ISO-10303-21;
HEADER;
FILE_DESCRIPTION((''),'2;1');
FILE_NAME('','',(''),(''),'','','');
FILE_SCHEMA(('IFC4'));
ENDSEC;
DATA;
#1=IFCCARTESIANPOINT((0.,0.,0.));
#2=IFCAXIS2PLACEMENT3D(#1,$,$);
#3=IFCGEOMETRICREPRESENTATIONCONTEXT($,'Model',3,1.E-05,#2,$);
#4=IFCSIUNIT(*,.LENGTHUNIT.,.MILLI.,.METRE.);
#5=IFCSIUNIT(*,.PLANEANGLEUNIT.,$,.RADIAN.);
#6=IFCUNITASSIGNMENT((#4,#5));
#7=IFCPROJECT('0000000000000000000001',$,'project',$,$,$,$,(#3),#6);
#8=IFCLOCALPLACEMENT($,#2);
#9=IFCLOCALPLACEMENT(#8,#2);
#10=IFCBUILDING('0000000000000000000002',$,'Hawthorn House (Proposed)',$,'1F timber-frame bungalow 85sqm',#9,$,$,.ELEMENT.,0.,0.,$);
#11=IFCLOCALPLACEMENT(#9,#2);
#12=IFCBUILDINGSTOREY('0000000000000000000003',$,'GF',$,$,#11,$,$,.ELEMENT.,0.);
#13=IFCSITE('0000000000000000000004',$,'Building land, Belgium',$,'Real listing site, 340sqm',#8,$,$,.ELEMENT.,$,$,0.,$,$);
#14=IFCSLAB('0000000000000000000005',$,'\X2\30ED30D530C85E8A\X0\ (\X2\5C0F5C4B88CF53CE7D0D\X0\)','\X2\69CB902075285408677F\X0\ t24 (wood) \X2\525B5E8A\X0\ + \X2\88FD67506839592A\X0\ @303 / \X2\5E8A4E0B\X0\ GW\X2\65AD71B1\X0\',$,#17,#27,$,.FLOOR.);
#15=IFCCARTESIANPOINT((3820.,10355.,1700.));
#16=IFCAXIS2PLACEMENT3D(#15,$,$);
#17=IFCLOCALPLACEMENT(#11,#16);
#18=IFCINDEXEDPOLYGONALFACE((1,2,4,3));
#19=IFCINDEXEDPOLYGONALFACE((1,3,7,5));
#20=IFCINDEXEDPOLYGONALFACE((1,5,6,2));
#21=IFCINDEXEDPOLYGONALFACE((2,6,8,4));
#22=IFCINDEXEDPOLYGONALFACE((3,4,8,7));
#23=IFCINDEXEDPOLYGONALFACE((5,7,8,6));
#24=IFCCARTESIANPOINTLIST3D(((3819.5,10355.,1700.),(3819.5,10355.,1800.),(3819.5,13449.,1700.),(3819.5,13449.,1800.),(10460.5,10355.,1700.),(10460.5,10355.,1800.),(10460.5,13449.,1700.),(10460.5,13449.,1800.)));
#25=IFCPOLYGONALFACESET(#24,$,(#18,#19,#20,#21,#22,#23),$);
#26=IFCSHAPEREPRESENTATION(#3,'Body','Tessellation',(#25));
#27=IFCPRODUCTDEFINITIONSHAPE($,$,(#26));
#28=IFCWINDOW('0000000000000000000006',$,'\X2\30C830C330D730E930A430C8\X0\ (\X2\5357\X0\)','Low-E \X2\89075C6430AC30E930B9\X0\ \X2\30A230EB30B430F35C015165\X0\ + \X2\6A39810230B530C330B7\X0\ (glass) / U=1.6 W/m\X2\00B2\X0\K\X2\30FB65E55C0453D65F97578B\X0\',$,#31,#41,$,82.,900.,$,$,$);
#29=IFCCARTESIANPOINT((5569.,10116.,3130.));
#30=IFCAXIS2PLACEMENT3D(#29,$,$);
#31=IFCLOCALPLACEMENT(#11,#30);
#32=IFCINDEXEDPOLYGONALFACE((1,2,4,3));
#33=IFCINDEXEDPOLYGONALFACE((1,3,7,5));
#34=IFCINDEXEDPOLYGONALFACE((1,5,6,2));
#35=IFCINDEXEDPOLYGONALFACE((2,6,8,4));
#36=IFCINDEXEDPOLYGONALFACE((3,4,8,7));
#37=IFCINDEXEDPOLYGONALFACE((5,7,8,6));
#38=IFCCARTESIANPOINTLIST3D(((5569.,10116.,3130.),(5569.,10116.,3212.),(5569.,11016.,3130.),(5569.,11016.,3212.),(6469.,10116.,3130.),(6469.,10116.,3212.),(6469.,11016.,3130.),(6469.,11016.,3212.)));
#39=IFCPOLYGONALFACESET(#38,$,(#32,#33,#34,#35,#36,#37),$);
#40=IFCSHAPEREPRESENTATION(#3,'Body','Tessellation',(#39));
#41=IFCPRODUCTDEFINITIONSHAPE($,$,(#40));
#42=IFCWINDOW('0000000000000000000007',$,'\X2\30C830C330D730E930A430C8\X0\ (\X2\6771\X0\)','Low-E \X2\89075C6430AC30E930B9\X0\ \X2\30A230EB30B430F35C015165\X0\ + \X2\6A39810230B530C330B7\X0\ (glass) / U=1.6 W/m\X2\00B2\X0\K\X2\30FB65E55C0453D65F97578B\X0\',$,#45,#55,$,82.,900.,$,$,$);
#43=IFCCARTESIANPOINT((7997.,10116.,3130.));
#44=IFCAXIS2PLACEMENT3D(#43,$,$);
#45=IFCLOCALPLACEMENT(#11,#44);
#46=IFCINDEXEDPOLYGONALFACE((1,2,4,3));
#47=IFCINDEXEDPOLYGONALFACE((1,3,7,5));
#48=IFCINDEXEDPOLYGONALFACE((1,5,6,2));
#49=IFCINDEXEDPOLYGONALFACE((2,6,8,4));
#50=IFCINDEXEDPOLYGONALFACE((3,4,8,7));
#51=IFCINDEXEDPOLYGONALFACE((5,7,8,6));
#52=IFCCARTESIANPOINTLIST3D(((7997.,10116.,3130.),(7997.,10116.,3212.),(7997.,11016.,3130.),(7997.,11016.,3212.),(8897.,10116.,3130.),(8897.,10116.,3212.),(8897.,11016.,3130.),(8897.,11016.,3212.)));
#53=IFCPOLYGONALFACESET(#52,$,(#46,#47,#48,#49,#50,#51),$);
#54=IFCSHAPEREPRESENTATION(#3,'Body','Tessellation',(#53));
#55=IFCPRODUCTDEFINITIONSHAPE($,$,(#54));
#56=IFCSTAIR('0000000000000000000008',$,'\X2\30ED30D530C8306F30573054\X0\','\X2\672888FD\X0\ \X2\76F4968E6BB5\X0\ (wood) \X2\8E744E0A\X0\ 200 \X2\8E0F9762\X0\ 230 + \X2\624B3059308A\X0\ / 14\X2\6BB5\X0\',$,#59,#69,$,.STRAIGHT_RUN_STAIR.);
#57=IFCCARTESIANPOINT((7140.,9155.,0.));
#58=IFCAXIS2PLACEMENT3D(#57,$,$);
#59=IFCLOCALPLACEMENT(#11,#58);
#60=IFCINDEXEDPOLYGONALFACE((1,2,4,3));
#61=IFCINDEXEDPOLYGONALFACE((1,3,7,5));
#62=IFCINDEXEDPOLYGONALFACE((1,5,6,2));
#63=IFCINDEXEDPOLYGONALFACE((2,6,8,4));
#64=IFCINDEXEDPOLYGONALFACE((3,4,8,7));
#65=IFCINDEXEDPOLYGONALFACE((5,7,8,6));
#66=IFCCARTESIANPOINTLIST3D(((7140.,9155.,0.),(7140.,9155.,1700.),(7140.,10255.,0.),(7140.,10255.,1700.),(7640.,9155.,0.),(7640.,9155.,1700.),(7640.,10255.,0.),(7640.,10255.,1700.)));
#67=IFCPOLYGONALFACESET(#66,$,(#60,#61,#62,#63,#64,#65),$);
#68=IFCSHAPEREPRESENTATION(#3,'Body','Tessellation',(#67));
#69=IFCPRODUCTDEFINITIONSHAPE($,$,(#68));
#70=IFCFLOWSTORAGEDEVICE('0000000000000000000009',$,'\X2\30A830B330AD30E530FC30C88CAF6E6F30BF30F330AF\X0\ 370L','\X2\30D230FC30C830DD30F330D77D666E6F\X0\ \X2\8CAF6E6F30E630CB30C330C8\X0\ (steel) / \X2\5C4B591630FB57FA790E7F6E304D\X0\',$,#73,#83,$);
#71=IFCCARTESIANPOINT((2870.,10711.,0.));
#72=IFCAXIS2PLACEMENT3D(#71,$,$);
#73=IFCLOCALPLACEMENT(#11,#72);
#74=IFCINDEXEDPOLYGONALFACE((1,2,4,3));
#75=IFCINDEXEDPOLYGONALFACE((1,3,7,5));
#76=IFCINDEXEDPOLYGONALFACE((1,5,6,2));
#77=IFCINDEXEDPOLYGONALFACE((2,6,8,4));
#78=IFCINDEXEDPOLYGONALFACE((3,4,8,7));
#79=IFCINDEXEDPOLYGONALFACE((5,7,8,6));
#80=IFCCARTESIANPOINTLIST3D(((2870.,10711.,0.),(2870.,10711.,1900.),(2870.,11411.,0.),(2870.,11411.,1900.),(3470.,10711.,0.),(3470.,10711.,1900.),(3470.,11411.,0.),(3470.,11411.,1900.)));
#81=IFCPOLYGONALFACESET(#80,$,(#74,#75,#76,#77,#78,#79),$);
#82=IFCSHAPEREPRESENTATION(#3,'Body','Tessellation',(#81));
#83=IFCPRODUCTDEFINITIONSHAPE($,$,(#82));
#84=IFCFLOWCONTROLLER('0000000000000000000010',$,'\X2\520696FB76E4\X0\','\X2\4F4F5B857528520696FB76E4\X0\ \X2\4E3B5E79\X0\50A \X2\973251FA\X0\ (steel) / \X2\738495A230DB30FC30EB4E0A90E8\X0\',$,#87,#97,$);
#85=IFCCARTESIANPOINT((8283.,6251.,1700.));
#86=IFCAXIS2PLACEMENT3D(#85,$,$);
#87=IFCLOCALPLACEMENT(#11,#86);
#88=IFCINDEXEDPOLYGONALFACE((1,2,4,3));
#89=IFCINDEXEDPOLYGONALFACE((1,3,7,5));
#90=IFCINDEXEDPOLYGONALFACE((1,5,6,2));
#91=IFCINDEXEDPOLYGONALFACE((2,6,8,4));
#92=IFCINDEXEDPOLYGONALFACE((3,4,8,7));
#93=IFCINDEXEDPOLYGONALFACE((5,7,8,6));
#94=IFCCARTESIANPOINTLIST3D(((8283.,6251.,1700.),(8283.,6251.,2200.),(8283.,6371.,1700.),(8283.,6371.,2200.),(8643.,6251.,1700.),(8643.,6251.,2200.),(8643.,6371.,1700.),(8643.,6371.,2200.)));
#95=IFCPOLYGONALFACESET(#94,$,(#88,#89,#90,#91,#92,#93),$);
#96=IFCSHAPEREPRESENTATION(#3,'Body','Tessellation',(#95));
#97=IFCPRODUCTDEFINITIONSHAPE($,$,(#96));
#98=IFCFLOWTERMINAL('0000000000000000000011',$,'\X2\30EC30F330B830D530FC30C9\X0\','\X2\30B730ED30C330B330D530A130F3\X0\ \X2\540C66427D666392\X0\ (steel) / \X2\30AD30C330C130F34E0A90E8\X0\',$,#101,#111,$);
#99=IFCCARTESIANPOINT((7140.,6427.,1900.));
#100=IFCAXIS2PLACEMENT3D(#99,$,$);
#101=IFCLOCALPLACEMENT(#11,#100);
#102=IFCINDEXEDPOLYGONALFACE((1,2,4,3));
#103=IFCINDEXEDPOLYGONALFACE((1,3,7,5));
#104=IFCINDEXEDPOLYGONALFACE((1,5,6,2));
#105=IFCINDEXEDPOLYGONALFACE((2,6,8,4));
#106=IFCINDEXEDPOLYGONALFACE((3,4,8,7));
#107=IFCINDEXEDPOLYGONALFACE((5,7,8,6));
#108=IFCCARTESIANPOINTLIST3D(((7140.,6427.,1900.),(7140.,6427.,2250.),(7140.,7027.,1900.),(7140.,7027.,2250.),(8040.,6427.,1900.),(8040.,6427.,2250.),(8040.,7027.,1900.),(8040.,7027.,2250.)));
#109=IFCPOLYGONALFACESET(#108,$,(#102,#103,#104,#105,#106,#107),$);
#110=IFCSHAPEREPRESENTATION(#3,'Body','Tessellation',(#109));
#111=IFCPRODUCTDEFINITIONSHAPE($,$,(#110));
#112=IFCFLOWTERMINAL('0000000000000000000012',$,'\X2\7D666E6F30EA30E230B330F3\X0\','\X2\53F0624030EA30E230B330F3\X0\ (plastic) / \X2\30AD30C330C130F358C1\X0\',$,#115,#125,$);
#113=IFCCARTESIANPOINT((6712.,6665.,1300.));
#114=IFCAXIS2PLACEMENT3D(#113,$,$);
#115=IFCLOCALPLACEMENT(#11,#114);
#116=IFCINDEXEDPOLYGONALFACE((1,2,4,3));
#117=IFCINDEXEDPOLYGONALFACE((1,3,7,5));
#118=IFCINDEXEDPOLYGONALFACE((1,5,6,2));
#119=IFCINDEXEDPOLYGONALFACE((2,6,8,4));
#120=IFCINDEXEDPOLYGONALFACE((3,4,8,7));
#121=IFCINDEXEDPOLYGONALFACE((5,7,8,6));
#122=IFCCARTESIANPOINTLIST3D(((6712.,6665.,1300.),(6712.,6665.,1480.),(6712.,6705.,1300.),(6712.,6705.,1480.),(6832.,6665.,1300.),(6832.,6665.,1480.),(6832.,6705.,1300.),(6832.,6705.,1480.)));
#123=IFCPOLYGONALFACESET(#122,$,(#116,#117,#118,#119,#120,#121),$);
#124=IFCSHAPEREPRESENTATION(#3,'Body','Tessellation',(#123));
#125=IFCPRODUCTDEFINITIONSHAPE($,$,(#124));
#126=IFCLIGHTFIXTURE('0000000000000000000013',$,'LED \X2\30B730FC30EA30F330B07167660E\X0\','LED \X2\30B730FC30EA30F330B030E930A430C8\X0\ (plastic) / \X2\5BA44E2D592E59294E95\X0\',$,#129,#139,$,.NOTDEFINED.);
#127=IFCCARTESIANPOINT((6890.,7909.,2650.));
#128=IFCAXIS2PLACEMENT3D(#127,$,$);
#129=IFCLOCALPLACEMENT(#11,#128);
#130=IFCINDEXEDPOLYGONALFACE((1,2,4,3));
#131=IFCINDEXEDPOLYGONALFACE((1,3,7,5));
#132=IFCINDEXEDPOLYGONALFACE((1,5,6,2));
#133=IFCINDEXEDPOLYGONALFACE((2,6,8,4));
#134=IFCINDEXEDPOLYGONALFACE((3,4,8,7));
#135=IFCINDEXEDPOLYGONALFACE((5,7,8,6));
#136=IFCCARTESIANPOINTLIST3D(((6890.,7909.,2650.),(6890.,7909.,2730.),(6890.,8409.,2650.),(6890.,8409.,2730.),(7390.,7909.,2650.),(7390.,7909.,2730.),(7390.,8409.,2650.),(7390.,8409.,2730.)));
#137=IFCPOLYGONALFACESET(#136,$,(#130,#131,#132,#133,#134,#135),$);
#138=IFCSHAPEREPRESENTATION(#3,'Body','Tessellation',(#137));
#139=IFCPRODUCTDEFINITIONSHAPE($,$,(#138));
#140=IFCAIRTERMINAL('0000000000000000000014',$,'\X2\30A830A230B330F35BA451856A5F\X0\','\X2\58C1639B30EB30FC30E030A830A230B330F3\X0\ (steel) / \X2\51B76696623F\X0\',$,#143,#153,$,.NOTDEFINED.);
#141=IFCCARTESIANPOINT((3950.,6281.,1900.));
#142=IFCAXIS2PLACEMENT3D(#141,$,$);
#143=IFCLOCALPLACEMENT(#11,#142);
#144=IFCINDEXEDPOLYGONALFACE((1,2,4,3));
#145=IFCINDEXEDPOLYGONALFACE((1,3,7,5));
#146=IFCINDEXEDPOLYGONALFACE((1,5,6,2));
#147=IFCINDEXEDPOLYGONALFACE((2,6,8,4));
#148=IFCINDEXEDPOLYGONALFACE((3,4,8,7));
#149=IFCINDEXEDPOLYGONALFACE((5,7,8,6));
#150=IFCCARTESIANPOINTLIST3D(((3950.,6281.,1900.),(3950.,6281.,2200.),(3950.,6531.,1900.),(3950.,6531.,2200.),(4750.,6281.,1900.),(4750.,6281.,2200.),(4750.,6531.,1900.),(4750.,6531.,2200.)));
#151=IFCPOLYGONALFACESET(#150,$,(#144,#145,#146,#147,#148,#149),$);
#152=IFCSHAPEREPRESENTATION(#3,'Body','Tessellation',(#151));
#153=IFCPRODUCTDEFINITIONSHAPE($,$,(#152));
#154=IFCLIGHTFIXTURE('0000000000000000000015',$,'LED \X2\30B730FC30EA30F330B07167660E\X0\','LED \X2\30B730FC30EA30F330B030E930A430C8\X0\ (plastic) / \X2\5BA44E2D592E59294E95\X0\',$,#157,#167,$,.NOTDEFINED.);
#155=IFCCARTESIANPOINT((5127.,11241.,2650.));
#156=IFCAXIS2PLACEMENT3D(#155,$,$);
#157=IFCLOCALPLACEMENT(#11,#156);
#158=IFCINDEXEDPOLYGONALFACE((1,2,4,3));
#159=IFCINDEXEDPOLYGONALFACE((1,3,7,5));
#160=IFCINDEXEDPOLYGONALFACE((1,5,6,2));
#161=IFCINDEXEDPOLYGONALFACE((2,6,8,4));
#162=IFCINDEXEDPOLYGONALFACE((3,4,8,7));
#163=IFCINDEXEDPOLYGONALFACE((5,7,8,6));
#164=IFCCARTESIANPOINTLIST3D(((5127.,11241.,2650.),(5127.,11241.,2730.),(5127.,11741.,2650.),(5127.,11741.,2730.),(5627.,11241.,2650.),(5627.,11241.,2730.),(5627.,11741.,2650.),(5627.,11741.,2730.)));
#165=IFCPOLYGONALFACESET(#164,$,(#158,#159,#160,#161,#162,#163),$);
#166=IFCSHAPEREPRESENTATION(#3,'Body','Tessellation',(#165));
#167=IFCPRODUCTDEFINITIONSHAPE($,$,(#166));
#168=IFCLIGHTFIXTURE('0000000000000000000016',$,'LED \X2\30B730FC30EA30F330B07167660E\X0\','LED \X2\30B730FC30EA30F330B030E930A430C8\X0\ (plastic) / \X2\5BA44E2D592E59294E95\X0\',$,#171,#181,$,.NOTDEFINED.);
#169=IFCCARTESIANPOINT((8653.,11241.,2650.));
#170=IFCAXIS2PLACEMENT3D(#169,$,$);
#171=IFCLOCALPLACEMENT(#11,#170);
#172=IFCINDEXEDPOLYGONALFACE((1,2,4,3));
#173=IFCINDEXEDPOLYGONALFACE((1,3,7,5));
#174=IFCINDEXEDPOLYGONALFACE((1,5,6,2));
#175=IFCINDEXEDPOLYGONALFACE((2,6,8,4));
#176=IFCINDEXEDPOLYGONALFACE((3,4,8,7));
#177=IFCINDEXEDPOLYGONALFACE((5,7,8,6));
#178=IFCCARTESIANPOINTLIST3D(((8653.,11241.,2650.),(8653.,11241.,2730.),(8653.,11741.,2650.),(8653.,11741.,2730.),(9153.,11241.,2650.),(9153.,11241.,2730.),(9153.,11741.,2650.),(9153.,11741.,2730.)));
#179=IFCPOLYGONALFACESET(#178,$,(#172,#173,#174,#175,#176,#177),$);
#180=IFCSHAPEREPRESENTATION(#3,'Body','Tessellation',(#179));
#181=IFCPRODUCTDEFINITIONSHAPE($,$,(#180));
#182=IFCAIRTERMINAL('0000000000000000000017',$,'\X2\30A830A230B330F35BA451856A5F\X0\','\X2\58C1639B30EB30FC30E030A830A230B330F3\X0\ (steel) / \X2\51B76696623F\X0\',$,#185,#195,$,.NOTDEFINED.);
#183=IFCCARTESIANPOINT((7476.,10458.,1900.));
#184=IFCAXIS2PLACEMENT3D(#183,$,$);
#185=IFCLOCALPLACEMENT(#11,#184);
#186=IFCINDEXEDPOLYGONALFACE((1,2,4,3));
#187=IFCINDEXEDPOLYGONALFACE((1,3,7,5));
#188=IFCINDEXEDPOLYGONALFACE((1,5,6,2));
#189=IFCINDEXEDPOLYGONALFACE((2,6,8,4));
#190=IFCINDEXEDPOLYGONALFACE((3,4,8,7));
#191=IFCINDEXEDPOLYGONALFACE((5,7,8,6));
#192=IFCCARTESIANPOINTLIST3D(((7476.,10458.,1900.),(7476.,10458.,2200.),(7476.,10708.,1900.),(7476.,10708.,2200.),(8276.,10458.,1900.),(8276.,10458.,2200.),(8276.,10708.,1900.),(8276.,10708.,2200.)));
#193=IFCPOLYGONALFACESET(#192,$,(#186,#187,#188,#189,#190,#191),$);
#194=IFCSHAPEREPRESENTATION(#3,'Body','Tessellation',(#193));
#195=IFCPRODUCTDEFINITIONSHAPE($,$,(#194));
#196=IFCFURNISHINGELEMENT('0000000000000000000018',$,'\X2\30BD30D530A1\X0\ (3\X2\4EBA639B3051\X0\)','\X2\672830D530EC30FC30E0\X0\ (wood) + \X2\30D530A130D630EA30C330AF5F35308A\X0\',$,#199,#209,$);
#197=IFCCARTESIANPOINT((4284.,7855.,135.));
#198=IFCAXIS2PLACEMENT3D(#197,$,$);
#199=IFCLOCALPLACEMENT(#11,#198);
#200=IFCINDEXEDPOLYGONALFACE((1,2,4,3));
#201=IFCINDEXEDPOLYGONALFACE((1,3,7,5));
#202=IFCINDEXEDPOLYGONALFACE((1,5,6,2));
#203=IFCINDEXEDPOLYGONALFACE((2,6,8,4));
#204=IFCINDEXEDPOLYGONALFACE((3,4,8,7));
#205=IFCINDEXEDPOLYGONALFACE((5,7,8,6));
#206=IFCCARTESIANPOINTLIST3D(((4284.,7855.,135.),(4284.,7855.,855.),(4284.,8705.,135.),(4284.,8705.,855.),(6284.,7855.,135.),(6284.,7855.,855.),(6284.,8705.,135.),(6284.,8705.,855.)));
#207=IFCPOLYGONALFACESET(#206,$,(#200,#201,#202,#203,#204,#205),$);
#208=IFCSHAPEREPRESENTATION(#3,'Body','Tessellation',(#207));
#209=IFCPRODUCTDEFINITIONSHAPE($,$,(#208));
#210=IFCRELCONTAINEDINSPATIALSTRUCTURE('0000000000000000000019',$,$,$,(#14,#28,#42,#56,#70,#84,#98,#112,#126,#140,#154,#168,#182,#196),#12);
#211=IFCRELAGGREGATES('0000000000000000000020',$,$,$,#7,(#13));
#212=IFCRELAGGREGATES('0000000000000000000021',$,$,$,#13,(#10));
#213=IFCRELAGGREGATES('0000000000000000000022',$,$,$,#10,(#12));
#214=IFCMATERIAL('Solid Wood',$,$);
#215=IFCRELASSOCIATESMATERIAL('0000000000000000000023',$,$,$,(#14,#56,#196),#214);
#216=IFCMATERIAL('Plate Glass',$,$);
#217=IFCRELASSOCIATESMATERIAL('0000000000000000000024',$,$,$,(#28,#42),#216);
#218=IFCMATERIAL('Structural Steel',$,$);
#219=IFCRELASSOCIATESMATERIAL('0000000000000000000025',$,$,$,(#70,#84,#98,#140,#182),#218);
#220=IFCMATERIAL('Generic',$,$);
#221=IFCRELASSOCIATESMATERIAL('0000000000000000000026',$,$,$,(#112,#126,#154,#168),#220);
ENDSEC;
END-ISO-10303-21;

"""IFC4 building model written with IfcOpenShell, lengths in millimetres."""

from ifc_helpers import new_model, si_unit, frame, frame_2d, origin, place, context, project, spatial, rectangle, extrude, material, element, save


model = new_model("IFC4")

# Units and contexts
model_context = context("Model", 3, precision=1e-05, world=origin())
ifc_project = project(units=[si_unit("LENGTHUNIT", "METRE", prefix="MILLI"), si_unit("PLANEANGLEUNIT", "RADIAN")], contexts=[model_context])

# Site, building, storey
site_placement = place(None, origin())
site = spatial("IfcSite", under=ifc_project, at=site_placement, Name="Building land, Belgium", ObjectType="Real listing site, 340sqm", CompositionType="ELEMENT", RefElevation=0.0)
building_placement = place(site_placement, origin())
building = spatial("IfcBuilding", under=site, at=building_placement, Name="Hawthorn House (Proposed)", ObjectType="1F timber-frame bungalow 85sqm", CompositionType="ELEMENT", ElevationOfRefHeight=0.0, ElevationOfTerrain=0.0)
storey_placement = place(building_placement, origin())
storey = spatial("IfcBuildingStorey", under=building, at=storey_placement, Name="GF", CompositionType="ELEMENT", Elevation=0.0)

# Shared definitions
ifc_material_1 = material(Name="Solid Wood")

# Slab
slab_placement = place(storey_placement, frame((3820.0, 10355.0, 1700.0)))
element("IfcSlab", 1, at=slab_placement, inside=storey, material=ifc_material_1, Name="ロフト床 (小屋裏収納)", Description="構造用合板 t24 (wood) 剛床 + 製材根太 @303 / 床下 GW断熱", PredefinedType="FLOOR", context=model_context, shape_type="SweptSolid", body=[
    extrude(rectangle(XDim=6641.0, YDim=3094.0, at=frame_2d((3320.0, 1547.0))), frame((3820.0, 10355.0, 1700.0)), (0.0, 0.0, 1.0), 100.0),
])

# Windows
ifc_material_2 = material(Name="Plate Glass")
window_1_placement = place(storey_placement, frame((5569.0, 10116.0, 3130.0)))
element("IfcWindow", 2, at=window_1_placement, inside=storey, material=ifc_material_2, Name="トップライト (南)", Description="Low-E 複層ガラス アルゴン封入 + 樹脂サッシ (glass) / U=1.6 W/m²K・日射取得型", OverallHeight=82.0, OverallWidth=900.0, context=model_context, shape_type="SweptSolid", body=[
    extrude(rectangle(XDim=900.0, YDim=900.0, at=frame_2d((450.0, 450.0))), frame((5569.0, 10116.0, 3130.0)), (0.0, 0.0, 1.0), 82.0),
])
window_2_placement = place(storey_placement, frame((7997.0, 10116.0, 3130.0)))
element("IfcWindow", 3, at=window_2_placement, inside=storey, material=ifc_material_2, Name="トップライト (東)", Description="Low-E 複層ガラス アルゴン封入 + 樹脂サッシ (glass) / U=1.6 W/m²K・日射取得型", OverallHeight=82.0, OverallWidth=900.0, context=model_context, shape_type="SweptSolid", body=[
    extrude(rectangle(XDim=900.0, YDim=900.0, at=frame_2d((450.0, 450.0))), frame((7997.0, 10116.0, 3130.0)), (0.0, 0.0, 1.0), 82.0),
])

# Stair
stair_placement = place(storey_placement, frame((7140.0, 9155.0, 0.0)))
element("IfcStair", 4, at=stair_placement, inside=storey, material=ifc_material_1, Name="ロフトはしご", Description="木製 直階段 (wood) 蹴上 200 踏面 230 + 手すり / 14段", PredefinedType="STRAIGHT_RUN_STAIR", context=model_context, shape_type="SweptSolid", body=[
    extrude(rectangle(XDim=500.0, YDim=1100.0, at=frame_2d((250.0, 550.0))), frame((7140.0, 9155.0, 0.0)), (0.0, 0.0, 1.0), 1700.0),
])

# Flow storage device
ifc_material_3 = material(Name="Structural Steel")
flow_storage_device_placement = place(storey_placement, frame((2870.0, 10711.0, 0.0)))
element("IfcFlowStorageDevice", 5, at=flow_storage_device_placement, inside=storey, material=ifc_material_3, Name="エコキュート貯湯タンク 370L", Description="ヒートポンプ給湯 貯湯ユニット (steel) / 屋外・基礎置き", context=model_context, shape_type="SweptSolid", body=[
    extrude(rectangle(XDim=600.0, YDim=700.0, at=frame_2d((300.0, 350.0))), frame((2870.0, 10711.0, 0.0)), (0.0, 0.0, 1.0), 1900.0),
])

# Flow controller
flow_controller_placement = place(storey_placement, frame((8283.0, 6251.0, 1700.0)))
element("IfcFlowController", 6, at=flow_controller_placement, inside=storey, material=ifc_material_3, Name="分電盤", Description="住宅用分電盤 主幹50A 露出 (steel) / 玄関ホール上部", context=model_context, shape_type="SweptSolid", body=[
    extrude(rectangle(XDim=360.0, YDim=120.0, at=frame_2d((180.0, 60.0))), frame((8283.0, 6251.0, 1700.0)), (0.0, 0.0, 1.0), 500.0),
])

# Flow terminals
flow_terminal_1_placement = place(storey_placement, frame((7140.0, 6427.0, 1900.0)))
element("IfcFlowTerminal", 7, at=flow_terminal_1_placement, inside=storey, material=ifc_material_3, Name="レンジフード", Description="シロッコファン 同時給排 (steel) / キッチン上部", context=model_context, shape_type="SweptSolid", body=[
    extrude(rectangle(XDim=900.0, YDim=600.0, at=frame_2d((450.0, 300.0))), frame((7140.0, 6427.0, 1900.0)), (0.0, 0.0, 1.0), 350.0),
])
ifc_material_4 = material(Name="Generic")
flow_terminal_2_placement = place(storey_placement, frame((6712.0, 6665.0, 1300.0)))
element("IfcFlowTerminal", 8, at=flow_terminal_2_placement, inside=storey, material=ifc_material_4, Name="給湯リモコン", Description="台所リモコン (plastic) / キッチン壁", context=model_context, shape_type="SweptSolid", body=[
    extrude(rectangle(XDim=120.0, YDim=40.0, at=frame_2d((60.0, 20.0))), frame((6712.0, 6665.0, 1300.0)), (0.0, 0.0, 1.0), 180.0),
])

# Light fixture
light_fixture_1_placement = place(storey_placement, frame((6890.0, 7909.0, 2650.0)))
element("IfcLightFixture", 9, at=light_fixture_1_placement, inside=storey, material=ifc_material_4, Name="LED シーリング照明", Description="LED シーリングライト (plastic) / 室中央天井", PredefinedType="NOTDEFINED", context=model_context, shape_type="SweptSolid", body=[
    extrude(rectangle(XDim=500.0, YDim=500.0, at=frame_2d((250.0, 250.0))), frame((6890.0, 7909.0, 2650.0)), (0.0, 0.0, 1.0), 80.0),
])

# Air terminal
air_terminal_1_placement = place(storey_placement, frame((3950.0, 6281.0, 1900.0)))
element("IfcAirTerminal", 10, at=air_terminal_1_placement, inside=storey, material=ifc_material_3, Name="エアコン室内機", Description="壁掛ルームエアコン (steel) / 冷暖房", PredefinedType="NOTDEFINED", context=model_context, shape_type="SweptSolid", body=[
    extrude(rectangle(XDim=800.0, YDim=250.0, at=frame_2d((400.0, 125.0))), frame((3950.0, 6281.0, 1900.0)), (0.0, 0.0, 1.0), 300.0),
])

# Light fixtures
light_fixture_2_placement = place(storey_placement, frame((5127.0, 11241.0, 2650.0)))
element("IfcLightFixture", 11, at=light_fixture_2_placement, inside=storey, material=ifc_material_4, Name="LED シーリング照明", Description="LED シーリングライト (plastic) / 室中央天井", PredefinedType="NOTDEFINED", context=model_context, shape_type="SweptSolid", body=[
    extrude(rectangle(XDim=500.0, YDim=500.0, at=frame_2d((250.0, 250.0))), frame((5127.0, 11241.0, 2650.0)), (0.0, 0.0, 1.0), 80.0),
])
light_fixture_3_placement = place(storey_placement, frame((8653.0, 11241.0, 2650.0)))
element("IfcLightFixture", 12, at=light_fixture_3_placement, inside=storey, material=ifc_material_4, Name="LED シーリング照明", Description="LED シーリングライト (plastic) / 室中央天井", PredefinedType="NOTDEFINED", context=model_context, shape_type="SweptSolid", body=[
    extrude(rectangle(XDim=500.0, YDim=500.0, at=frame_2d((250.0, 250.0))), frame((8653.0, 11241.0, 2650.0)), (0.0, 0.0, 1.0), 80.0),
])

# Air terminal
air_terminal_2_placement = place(storey_placement, frame((7476.0, 10458.0, 1900.0)))
element("IfcAirTerminal", 13, at=air_terminal_2_placement, inside=storey, material=ifc_material_3, Name="エアコン室内機", Description="壁掛ルームエアコン (steel) / 冷暖房", PredefinedType="NOTDEFINED", context=model_context, shape_type="SweptSolid", body=[
    extrude(rectangle(XDim=800.0, YDim=250.0, at=frame_2d((400.0, 125.0))), frame((7476.0, 10458.0, 1900.0)), (0.0, 0.0, 1.0), 300.0),
])

# Furnishing element
furnishing_1_placement = place(storey_placement, frame((4284.0, 7855.0, 135.0)))
element("IfcFurnishingElement", 14, at=furnishing_1_placement, inside=storey, material=ifc_material_1, Name="ソファ (3人掛け)", Description="木フレーム (wood) + ファブリック張り", context=model_context, shape_type="SweptSolid", body=[
    extrude(rectangle(XDim=2000.0, YDim=850.0, at=frame_2d((1000.0, 425.0))), frame((4284.0, 7855.0, 135.0)), (0.0, 0.0, 1.0), 720.0),
])

save(model, "model.ifc")
